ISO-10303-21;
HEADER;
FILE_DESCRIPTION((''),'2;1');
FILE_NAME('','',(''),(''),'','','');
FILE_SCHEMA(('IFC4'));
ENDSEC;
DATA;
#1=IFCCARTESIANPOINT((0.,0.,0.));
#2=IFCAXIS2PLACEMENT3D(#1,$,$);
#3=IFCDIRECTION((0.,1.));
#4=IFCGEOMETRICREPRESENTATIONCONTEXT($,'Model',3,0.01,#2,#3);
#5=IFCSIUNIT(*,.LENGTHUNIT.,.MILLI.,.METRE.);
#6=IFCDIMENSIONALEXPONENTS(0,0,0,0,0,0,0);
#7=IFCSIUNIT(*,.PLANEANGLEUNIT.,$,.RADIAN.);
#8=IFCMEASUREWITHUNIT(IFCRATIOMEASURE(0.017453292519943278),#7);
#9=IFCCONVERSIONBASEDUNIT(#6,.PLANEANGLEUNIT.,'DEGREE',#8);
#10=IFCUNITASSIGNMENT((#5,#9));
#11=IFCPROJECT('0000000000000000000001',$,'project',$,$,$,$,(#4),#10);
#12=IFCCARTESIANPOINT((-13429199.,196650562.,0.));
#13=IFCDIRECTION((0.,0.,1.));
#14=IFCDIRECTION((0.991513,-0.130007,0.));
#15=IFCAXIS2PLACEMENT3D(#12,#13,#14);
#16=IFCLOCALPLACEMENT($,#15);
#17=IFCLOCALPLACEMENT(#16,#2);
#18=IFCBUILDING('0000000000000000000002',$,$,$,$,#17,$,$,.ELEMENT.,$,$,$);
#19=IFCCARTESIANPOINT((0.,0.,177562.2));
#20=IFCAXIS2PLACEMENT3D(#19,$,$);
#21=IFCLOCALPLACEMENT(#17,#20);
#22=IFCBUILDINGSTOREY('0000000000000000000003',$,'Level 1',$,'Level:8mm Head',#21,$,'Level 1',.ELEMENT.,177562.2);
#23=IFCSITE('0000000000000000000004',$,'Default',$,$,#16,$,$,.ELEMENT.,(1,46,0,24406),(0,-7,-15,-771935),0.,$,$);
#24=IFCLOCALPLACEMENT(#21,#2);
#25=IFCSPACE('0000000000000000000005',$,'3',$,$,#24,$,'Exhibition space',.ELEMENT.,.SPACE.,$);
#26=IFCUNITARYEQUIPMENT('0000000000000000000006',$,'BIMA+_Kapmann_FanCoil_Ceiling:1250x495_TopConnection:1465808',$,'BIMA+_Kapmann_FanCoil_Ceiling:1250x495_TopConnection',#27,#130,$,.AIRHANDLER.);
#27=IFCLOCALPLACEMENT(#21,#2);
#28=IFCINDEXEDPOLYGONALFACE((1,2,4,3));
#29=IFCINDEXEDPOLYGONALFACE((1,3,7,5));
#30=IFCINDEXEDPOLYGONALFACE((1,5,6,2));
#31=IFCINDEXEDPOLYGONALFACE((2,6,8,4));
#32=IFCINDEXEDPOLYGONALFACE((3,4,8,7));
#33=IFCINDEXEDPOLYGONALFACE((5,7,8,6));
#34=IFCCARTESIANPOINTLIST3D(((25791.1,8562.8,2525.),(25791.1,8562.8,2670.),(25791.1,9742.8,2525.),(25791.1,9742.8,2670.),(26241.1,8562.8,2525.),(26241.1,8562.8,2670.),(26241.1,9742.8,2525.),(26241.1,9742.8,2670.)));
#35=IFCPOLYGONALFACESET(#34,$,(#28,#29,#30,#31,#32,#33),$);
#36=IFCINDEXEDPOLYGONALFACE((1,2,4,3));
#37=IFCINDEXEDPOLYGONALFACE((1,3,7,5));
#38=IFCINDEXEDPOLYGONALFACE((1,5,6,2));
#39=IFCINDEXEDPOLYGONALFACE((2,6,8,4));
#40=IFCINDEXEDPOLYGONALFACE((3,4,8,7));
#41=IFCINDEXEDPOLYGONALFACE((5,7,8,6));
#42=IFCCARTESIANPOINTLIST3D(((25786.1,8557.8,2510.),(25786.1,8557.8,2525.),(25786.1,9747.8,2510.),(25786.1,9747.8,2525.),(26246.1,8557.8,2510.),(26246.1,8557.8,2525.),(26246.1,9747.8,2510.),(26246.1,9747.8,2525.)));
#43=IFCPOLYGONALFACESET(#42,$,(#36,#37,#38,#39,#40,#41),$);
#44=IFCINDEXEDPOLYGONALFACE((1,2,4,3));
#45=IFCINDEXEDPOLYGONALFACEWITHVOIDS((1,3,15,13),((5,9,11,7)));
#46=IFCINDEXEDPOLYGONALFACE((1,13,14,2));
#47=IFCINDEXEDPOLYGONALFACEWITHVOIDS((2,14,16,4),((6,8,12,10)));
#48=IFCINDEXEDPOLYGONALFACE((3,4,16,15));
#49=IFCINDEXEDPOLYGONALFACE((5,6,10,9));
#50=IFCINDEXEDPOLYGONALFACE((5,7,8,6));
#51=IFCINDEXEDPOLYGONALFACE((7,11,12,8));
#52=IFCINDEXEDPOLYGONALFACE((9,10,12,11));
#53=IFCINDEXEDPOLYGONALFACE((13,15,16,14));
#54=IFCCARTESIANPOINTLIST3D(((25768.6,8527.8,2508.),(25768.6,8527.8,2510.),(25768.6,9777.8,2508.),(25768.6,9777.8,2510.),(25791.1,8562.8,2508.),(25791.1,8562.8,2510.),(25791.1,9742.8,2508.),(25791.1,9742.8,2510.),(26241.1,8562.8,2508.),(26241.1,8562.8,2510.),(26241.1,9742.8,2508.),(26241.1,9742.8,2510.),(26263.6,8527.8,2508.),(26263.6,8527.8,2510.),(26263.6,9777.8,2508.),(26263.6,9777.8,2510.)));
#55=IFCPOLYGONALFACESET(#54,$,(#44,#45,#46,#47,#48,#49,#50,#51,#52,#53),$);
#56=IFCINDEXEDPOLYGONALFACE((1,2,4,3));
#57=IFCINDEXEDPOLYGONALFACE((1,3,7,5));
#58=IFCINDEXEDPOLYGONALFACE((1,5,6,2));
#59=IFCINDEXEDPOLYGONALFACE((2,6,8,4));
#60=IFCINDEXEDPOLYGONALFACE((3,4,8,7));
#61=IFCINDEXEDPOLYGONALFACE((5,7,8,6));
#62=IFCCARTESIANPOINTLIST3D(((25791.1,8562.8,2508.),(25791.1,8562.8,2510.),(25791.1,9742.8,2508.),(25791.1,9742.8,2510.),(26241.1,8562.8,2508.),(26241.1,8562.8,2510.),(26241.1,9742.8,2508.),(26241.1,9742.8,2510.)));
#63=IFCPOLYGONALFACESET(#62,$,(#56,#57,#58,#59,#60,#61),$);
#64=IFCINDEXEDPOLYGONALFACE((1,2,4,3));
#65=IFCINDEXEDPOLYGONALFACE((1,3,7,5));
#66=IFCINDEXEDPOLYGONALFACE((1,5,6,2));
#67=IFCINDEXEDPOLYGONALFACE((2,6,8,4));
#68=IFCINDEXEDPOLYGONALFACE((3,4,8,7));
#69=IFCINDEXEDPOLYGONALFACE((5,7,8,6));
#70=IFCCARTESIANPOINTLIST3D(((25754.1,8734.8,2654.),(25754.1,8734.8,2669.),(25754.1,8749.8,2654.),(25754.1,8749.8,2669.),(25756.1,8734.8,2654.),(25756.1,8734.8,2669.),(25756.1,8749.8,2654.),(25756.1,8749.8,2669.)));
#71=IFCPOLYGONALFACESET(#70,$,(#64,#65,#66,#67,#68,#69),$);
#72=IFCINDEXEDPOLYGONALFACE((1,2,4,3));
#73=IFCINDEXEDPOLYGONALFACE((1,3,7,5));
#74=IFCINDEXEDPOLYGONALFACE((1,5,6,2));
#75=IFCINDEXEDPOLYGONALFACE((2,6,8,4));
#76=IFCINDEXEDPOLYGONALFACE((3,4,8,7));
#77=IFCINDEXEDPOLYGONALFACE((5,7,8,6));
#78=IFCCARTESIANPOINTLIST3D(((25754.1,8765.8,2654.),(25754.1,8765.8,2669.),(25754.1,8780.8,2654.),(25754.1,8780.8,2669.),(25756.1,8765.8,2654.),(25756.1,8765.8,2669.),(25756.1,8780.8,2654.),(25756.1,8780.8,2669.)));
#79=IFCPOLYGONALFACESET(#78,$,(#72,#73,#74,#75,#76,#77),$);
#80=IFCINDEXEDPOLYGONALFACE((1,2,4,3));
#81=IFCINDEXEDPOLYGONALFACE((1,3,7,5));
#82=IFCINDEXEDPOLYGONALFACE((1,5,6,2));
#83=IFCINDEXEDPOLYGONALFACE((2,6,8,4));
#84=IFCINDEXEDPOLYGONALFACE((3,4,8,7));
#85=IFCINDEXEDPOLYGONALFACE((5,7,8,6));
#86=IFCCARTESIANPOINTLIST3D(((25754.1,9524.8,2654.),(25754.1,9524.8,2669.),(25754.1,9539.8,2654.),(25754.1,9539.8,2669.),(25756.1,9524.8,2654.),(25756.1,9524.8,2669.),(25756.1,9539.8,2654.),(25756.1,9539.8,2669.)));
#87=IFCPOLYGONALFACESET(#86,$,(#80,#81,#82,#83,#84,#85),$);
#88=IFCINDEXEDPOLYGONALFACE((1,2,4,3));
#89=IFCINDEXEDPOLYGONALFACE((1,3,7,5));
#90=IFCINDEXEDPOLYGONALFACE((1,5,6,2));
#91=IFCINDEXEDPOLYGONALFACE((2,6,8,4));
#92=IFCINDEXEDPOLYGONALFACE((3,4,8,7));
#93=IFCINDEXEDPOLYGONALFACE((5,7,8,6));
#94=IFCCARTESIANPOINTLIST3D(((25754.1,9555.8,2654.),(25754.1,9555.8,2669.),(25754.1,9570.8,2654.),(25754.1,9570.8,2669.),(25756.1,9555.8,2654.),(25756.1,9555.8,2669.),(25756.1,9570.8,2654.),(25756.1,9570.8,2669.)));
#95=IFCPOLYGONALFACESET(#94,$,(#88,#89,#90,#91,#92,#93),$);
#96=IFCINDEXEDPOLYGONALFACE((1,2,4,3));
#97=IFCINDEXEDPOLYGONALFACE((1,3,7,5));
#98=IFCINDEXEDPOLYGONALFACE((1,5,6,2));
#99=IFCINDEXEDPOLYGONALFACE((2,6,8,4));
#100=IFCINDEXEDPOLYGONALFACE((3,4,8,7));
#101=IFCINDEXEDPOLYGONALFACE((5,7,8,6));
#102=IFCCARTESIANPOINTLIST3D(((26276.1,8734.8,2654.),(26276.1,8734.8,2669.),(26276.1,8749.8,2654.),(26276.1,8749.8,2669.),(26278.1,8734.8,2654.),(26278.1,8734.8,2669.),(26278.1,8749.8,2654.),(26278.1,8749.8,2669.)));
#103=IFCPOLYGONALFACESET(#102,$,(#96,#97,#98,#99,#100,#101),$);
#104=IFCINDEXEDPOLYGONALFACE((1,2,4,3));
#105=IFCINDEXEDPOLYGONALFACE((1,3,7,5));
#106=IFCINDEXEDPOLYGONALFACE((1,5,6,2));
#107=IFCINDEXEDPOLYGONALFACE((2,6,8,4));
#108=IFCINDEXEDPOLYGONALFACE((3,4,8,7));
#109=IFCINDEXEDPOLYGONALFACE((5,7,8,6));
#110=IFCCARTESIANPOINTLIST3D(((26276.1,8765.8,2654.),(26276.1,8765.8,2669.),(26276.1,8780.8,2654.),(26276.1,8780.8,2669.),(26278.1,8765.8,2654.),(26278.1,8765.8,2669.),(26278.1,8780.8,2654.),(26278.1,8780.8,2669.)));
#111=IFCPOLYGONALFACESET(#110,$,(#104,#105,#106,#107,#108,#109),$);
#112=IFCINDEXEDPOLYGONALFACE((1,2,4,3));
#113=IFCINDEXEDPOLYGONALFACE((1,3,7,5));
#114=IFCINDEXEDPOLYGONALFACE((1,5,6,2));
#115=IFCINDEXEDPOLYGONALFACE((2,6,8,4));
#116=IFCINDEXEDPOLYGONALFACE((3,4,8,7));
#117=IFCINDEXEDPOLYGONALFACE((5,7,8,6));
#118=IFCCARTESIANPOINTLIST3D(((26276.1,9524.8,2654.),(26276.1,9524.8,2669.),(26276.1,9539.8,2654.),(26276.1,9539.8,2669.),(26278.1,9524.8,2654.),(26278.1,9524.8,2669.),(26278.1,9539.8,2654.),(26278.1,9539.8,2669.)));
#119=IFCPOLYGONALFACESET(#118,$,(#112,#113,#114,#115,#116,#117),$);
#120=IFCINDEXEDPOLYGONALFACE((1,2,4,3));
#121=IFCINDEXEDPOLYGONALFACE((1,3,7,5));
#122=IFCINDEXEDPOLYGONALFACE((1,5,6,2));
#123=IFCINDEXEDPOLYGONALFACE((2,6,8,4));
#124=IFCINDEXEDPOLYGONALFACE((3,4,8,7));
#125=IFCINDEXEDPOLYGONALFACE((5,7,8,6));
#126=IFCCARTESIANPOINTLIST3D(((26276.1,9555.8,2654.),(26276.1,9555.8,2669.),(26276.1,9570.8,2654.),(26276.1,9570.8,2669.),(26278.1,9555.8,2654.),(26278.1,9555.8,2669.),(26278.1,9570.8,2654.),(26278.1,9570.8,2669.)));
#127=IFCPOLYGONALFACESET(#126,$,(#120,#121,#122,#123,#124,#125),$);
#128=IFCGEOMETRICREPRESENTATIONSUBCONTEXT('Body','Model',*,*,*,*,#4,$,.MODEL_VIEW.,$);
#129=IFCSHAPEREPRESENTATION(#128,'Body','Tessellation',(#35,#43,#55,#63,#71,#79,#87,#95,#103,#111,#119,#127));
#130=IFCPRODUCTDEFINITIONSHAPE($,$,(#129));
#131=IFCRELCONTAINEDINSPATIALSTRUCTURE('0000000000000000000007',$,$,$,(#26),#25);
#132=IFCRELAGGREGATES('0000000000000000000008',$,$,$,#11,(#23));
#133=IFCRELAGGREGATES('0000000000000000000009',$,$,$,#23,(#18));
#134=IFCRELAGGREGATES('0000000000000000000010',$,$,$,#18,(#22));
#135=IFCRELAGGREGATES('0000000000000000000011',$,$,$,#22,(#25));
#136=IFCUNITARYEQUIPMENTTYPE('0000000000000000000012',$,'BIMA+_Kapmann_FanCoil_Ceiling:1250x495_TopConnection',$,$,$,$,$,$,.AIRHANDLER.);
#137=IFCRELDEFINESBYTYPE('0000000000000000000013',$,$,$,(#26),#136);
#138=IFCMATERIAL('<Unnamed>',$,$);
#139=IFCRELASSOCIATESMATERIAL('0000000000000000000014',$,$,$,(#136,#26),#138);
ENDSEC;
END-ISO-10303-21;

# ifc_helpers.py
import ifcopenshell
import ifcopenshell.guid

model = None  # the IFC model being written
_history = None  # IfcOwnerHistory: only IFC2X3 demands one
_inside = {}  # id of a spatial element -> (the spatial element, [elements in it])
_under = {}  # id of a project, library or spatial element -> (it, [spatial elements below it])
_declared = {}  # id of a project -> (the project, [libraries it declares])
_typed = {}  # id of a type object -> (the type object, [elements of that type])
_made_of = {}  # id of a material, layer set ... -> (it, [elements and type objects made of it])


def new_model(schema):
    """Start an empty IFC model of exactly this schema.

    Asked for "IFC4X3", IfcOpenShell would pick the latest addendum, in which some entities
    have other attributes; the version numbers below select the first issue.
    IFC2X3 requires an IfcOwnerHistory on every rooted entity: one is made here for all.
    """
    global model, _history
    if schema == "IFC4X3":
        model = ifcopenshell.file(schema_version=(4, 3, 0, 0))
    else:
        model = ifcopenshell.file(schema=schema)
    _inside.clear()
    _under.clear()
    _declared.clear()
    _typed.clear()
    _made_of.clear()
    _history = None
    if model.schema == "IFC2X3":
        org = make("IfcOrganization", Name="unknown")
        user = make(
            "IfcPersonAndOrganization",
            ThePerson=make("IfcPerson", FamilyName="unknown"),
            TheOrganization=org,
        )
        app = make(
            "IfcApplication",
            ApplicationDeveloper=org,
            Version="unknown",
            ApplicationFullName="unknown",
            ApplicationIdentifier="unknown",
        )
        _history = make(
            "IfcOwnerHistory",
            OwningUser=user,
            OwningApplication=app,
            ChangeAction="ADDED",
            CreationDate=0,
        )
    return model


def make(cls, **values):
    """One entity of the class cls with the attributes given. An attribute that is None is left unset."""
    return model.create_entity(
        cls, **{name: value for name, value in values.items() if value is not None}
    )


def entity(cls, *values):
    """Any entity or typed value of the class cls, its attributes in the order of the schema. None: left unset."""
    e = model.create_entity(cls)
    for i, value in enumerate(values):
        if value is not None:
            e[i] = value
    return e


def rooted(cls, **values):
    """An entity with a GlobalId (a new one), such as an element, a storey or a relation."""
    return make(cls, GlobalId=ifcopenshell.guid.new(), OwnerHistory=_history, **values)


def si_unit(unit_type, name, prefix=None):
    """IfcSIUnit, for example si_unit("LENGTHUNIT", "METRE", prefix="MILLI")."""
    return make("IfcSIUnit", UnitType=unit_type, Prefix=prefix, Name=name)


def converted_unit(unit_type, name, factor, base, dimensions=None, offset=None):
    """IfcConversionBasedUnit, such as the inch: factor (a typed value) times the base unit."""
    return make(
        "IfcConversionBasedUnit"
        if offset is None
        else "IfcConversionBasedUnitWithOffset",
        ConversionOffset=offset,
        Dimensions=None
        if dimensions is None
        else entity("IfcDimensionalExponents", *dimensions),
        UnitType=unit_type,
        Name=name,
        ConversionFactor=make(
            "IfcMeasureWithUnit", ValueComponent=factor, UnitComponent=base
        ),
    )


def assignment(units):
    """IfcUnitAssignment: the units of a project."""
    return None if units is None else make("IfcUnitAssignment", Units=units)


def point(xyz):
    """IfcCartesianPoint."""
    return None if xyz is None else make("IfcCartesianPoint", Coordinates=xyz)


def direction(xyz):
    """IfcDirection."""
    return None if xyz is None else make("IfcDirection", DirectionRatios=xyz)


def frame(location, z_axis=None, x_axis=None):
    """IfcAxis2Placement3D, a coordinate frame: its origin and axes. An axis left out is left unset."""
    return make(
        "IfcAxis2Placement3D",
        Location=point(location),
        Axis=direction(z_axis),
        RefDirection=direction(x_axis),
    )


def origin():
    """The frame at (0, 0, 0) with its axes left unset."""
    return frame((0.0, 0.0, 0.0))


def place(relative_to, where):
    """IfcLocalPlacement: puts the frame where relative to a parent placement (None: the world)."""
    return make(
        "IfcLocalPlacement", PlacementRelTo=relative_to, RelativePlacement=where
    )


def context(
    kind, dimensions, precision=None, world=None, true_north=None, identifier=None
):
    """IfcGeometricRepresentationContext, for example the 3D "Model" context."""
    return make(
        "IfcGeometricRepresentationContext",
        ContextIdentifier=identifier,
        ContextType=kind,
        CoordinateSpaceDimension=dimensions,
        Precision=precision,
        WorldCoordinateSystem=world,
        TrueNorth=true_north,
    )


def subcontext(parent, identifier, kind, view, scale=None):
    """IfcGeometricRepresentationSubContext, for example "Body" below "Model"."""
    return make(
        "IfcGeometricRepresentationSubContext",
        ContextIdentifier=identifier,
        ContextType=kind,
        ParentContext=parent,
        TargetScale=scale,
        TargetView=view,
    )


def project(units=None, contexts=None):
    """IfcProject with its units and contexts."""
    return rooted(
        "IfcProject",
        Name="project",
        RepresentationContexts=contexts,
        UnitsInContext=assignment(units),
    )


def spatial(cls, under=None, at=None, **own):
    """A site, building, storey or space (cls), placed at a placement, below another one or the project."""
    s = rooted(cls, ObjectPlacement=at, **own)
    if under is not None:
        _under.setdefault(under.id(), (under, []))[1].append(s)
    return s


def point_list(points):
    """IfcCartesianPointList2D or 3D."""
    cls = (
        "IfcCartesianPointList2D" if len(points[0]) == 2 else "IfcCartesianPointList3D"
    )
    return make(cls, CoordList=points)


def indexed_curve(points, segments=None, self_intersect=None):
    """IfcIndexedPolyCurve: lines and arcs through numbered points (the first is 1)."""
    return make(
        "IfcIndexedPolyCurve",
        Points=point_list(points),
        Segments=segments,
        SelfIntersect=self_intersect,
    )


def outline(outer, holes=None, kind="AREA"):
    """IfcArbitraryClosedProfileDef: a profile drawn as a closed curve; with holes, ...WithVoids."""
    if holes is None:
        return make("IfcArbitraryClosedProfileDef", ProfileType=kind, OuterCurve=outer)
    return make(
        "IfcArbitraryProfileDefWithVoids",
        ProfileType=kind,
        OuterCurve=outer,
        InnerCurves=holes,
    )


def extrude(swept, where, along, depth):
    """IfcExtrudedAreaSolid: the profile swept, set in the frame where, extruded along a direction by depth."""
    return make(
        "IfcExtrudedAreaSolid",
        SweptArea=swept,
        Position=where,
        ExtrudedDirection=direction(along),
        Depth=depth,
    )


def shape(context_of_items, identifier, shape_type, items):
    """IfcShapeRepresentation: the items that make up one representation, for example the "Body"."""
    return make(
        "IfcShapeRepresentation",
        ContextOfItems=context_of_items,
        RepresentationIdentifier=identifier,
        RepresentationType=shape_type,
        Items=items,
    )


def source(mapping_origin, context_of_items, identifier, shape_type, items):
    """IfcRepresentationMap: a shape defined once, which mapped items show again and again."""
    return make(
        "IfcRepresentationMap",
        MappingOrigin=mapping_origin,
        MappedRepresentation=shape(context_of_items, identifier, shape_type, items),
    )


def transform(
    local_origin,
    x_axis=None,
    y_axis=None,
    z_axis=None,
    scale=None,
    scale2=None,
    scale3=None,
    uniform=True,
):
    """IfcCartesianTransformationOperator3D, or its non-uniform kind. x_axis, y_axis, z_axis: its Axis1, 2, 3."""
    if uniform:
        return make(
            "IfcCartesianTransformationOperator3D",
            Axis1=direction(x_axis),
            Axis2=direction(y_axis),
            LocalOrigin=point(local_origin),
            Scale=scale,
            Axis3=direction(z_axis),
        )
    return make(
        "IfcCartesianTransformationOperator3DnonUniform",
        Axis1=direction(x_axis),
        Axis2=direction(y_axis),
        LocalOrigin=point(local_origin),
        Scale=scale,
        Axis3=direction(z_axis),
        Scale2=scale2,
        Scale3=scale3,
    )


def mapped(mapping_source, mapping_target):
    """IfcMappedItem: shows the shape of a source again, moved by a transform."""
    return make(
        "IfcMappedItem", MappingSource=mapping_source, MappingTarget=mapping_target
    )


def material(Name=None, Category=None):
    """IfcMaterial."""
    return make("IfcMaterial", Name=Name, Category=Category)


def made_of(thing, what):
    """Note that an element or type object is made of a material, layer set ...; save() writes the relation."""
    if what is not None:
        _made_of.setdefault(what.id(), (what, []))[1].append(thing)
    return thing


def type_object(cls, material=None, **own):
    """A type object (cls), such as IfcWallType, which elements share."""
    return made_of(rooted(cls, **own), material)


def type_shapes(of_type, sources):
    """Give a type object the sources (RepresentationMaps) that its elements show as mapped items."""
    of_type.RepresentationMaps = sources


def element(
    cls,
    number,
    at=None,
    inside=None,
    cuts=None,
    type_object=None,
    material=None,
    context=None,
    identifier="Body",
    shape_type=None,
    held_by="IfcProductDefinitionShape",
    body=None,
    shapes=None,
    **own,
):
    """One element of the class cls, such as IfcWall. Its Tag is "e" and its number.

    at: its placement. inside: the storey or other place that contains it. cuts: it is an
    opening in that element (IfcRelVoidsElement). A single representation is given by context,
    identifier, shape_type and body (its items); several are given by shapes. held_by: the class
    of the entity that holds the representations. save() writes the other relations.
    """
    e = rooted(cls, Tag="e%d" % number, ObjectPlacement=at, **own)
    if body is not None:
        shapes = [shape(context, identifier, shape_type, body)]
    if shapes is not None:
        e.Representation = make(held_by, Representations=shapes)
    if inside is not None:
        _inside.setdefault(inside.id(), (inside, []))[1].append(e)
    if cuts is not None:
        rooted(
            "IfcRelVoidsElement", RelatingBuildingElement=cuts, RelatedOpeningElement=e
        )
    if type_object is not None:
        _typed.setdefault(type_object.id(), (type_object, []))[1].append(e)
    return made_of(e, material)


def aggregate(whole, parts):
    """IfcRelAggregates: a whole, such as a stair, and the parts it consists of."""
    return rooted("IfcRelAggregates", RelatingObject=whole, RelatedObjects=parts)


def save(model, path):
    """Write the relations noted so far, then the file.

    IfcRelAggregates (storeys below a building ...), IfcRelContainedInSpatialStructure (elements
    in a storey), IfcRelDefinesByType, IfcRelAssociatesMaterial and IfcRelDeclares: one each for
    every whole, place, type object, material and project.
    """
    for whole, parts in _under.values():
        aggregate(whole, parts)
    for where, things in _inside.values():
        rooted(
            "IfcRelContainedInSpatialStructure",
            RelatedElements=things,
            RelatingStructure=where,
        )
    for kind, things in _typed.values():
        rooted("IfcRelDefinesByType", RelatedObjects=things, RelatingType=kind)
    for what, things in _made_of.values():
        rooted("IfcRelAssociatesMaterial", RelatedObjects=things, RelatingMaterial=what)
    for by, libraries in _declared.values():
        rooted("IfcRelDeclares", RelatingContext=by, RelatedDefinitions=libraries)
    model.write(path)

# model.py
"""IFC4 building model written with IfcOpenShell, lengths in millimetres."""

from ifc_helpers import new_model, entity, si_unit, converted_unit, direction, frame, origin, place, context, subcontext, project, spatial, indexed_curve, outline, extrude, source, transform, mapped, material, type_object, type_shapes, element, save


model = new_model("IFC4")

# Units and contexts
model_context = context("Model", 3, precision=0.01, world=origin(), true_north=direction((0.0, 1.0)))
body_context = subcontext(model_context, "Body", "Model", "MODEL_VIEW")
ifc_project = project(units=[si_unit("LENGTHUNIT", "METRE", prefix="MILLI"), converted_unit("PLANEANGLEUNIT", "DEGREE", entity("IfcRatioMeasure", 0.017453292519943278), si_unit("PLANEANGLEUNIT", "RADIAN"), dimensions=[0, 0, 0, 0, 0, 0, 0])], contexts=[model_context])

# Site, building, storey
site_placement = place(None, frame((-13429199.0, 196650562.0, 0.0), z_axis=(0.0, 0.0, 1.0), x_axis=(0.991513, -0.130007, 0.0)))
site = spatial("IfcSite", under=ifc_project, at=site_placement, Name="Default", CompositionType="ELEMENT", RefLatitude=(1, 46, 0, 24406), RefLongitude=(0, -7, -15, -771935), RefElevation=0.0)
building_placement = place(site_placement, origin())
building = spatial("IfcBuilding", under=site, at=building_placement, CompositionType="ELEMENT")
storey_placement = place(building_placement, frame((0.0, 0.0, 177562.2)))
storey = spatial("IfcBuildingStorey", under=building, at=storey_placement, Name="Level 1", ObjectType="Level:8mm Head", LongName="Level 1", CompositionType="ELEMENT", Elevation=177562.2)

# Shared definitions
space_placement = place(storey_placement, origin())
space = spatial("IfcSpace", under=storey, at=space_placement, Name="3", LongName="Exhibition space", CompositionType="ELEMENT", PredefinedType="SPACE")

# Unitary equipment
ifc_material_1 = material(Name="<Unnamed>")
unitary_equipment_type = type_object("IfcUnitaryEquipmentType", Name="BIMA+_Kapmann_FanCoil_Ceiling:1250x495_TopConnection", PredefinedType="AIRHANDLER", material=ifc_material_1)
shared_shape = source(origin(), body_context, "Body", "SweptSolid", [
    extrude(outline(indexed_curve([(-590.0, -225.0), (590.0, -225.0), (590.0, 225.0), (-590.0, 225.0), (-590.0, -225.0)], self_intersect=False)), frame((0.0, 0.0, 15.0)), (0.0, 0.0, 1.0), 145.0),
    extrude(outline(indexed_curve([(-595.0, -230.0), (595.0, -230.0), (595.0, 230.0), (-595.0, 230.0), (-595.0, -230.0)], self_intersect=False)), frame((0.0, 0.0, 0.0), z_axis=(0.0, 0.0, 1.0), x_axis=(-1.0, 0.0, 0.0)), (0.0, 0.0, 1.0), 15.0),
    extrude(outline(indexed_curve([(-625.0, -247.5), (625.0, -247.5), (625.0, 247.5), (-625.0, 247.5), (-625.0, -247.5)], self_intersect=False), holes=[indexed_curve([(-590.0, -225.0), (-590.0, 225.0), (590.0, 225.0), (590.0, -225.0), (-590.0, -225.0)], self_intersect=False)]), frame((0.0, 0.0, -2.0), z_axis=(0.0, 0.0, 1.0), x_axis=(-1.0, 0.0, 0.0)), (0.0, 0.0, 1.0), 2.0),
    extrude(outline(indexed_curve([(-590.0, -225.0), (590.0, -225.0), (590.0, 225.0), (-590.0, 225.0), (-590.0, -225.0)], self_intersect=False)), frame((0.0, 0.0, -2.0), z_axis=(0.0, 0.0, 1.0), x_axis=(-1.0, 0.0, 0.0)), (0.0, 0.0, 1.0), 2.0),
    extrude(outline(indexed_curve([(-1.0, -7.5), (1.0, -7.5), (1.0, 7.5), (-1.0, 7.5), (-1.0, -7.5)], self_intersect=False)), frame((-410.5, 261.0, 144.0), z_axis=(0.0, 0.0, 1.0), x_axis=(0.0, -1.0, 0.0)), (0.0, 0.0, 1.0), 15.0),
    extrude(outline(indexed_curve([(-1.0, -7.5), (1.0, -7.5), (1.0, 7.5), (-1.0, 7.5), (-1.0, -7.5)], self_intersect=False)), frame((-379.5, 261.0, 144.0), z_axis=(0.0, 0.0, 1.0), x_axis=(0.0, -1.0, 0.0)), (0.0, 0.0, 1.0), 15.0),
    extrude(outline(indexed_curve([(-1.0, -7.5), (1.0, -7.5), (1.0, 7.5), (-1.0, 7.5), (-1.0, -7.5)], self_intersect=False)), frame((379.5, 261.0, 144.0), z_axis=(0.0, 0.0, 1.0), x_axis=(0.0, -1.0, 0.0)), (0.0, 0.0, 1.0), 15.0),
    extrude(outline(indexed_curve([(-1.0, -7.5), (1.0, -7.5), (1.0, 7.5), (-1.0, 7.5), (-1.0, -7.5)], self_intersect=False)), frame((410.5, 261.0, 144.0), z_axis=(0.0, 0.0, 1.0), x_axis=(0.0, -1.0, 0.0)), (0.0, 0.0, 1.0), 15.0),
    extrude(outline(indexed_curve([(-1.0, -7.5), (1.0, -7.5), (1.0, 7.5), (-1.0, 7.5), (-1.0, -7.5)], self_intersect=False)), frame((-410.5, -261.0, 144.0), z_axis=(0.0, 0.0, 1.0), x_axis=(0.0, -1.0, 0.0)), (0.0, 0.0, 1.0), 15.0),
    extrude(outline(indexed_curve([(-1.0, -7.5), (1.0, -7.5), (1.0, 7.5), (-1.0, 7.5), (-1.0, -7.5)], self_intersect=False)), frame((-379.5, -261.0, 144.0), z_axis=(0.0, 0.0, 1.0), x_axis=(0.0, -1.0, 0.0)), (0.0, 0.0, 1.0), 15.0),
    extrude(outline(indexed_curve([(-1.0, -7.5), (1.0, -7.5), (1.0, 7.5), (-1.0, 7.5), (-1.0, -7.5)], self_intersect=False)), frame((379.5, -261.0, 144.0), z_axis=(0.0, 0.0, 1.0), x_axis=(0.0, -1.0, 0.0)), (0.0, 0.0, 1.0), 15.0),
    extrude(outline(indexed_curve([(-1.0, -7.5), (1.0, -7.5), (1.0, 7.5), (-1.0, 7.5), (-1.0, -7.5)], self_intersect=False)), frame((410.5, -261.0, 144.0), z_axis=(0.0, 0.0, 1.0), x_axis=(0.0, -1.0, 0.0)), (0.0, 0.0, 1.0), 15.0),
])
type_shapes(unitary_equipment_type, [shared_shape])
unitary_equipment_placement = place(space_placement, frame((26016.1, 9152.8, 2510.0), z_axis=(0.0, 0.0, 1.0), x_axis=(0.0, 1.0, 0.0)))
element("IfcUnitaryEquipment", 1, at=unitary_equipment_placement, inside=space, type_object=unitary_equipment_type, material=ifc_material_1, Name="BIMA+_Kapmann_FanCoil_Ceiling:1250x495_TopConnection:1465808", ObjectType="BIMA+_Kapmann_FanCoil_Ceiling:1250x495_TopConnection", PredefinedType="AIRHANDLER", context=body_context, shape_type="MappedRepresentation", body=[
    mapped(shared_shape, transform((0.0, 0.0, 0.0), scale=1.0)),
])

save(model, "model.ifc")
